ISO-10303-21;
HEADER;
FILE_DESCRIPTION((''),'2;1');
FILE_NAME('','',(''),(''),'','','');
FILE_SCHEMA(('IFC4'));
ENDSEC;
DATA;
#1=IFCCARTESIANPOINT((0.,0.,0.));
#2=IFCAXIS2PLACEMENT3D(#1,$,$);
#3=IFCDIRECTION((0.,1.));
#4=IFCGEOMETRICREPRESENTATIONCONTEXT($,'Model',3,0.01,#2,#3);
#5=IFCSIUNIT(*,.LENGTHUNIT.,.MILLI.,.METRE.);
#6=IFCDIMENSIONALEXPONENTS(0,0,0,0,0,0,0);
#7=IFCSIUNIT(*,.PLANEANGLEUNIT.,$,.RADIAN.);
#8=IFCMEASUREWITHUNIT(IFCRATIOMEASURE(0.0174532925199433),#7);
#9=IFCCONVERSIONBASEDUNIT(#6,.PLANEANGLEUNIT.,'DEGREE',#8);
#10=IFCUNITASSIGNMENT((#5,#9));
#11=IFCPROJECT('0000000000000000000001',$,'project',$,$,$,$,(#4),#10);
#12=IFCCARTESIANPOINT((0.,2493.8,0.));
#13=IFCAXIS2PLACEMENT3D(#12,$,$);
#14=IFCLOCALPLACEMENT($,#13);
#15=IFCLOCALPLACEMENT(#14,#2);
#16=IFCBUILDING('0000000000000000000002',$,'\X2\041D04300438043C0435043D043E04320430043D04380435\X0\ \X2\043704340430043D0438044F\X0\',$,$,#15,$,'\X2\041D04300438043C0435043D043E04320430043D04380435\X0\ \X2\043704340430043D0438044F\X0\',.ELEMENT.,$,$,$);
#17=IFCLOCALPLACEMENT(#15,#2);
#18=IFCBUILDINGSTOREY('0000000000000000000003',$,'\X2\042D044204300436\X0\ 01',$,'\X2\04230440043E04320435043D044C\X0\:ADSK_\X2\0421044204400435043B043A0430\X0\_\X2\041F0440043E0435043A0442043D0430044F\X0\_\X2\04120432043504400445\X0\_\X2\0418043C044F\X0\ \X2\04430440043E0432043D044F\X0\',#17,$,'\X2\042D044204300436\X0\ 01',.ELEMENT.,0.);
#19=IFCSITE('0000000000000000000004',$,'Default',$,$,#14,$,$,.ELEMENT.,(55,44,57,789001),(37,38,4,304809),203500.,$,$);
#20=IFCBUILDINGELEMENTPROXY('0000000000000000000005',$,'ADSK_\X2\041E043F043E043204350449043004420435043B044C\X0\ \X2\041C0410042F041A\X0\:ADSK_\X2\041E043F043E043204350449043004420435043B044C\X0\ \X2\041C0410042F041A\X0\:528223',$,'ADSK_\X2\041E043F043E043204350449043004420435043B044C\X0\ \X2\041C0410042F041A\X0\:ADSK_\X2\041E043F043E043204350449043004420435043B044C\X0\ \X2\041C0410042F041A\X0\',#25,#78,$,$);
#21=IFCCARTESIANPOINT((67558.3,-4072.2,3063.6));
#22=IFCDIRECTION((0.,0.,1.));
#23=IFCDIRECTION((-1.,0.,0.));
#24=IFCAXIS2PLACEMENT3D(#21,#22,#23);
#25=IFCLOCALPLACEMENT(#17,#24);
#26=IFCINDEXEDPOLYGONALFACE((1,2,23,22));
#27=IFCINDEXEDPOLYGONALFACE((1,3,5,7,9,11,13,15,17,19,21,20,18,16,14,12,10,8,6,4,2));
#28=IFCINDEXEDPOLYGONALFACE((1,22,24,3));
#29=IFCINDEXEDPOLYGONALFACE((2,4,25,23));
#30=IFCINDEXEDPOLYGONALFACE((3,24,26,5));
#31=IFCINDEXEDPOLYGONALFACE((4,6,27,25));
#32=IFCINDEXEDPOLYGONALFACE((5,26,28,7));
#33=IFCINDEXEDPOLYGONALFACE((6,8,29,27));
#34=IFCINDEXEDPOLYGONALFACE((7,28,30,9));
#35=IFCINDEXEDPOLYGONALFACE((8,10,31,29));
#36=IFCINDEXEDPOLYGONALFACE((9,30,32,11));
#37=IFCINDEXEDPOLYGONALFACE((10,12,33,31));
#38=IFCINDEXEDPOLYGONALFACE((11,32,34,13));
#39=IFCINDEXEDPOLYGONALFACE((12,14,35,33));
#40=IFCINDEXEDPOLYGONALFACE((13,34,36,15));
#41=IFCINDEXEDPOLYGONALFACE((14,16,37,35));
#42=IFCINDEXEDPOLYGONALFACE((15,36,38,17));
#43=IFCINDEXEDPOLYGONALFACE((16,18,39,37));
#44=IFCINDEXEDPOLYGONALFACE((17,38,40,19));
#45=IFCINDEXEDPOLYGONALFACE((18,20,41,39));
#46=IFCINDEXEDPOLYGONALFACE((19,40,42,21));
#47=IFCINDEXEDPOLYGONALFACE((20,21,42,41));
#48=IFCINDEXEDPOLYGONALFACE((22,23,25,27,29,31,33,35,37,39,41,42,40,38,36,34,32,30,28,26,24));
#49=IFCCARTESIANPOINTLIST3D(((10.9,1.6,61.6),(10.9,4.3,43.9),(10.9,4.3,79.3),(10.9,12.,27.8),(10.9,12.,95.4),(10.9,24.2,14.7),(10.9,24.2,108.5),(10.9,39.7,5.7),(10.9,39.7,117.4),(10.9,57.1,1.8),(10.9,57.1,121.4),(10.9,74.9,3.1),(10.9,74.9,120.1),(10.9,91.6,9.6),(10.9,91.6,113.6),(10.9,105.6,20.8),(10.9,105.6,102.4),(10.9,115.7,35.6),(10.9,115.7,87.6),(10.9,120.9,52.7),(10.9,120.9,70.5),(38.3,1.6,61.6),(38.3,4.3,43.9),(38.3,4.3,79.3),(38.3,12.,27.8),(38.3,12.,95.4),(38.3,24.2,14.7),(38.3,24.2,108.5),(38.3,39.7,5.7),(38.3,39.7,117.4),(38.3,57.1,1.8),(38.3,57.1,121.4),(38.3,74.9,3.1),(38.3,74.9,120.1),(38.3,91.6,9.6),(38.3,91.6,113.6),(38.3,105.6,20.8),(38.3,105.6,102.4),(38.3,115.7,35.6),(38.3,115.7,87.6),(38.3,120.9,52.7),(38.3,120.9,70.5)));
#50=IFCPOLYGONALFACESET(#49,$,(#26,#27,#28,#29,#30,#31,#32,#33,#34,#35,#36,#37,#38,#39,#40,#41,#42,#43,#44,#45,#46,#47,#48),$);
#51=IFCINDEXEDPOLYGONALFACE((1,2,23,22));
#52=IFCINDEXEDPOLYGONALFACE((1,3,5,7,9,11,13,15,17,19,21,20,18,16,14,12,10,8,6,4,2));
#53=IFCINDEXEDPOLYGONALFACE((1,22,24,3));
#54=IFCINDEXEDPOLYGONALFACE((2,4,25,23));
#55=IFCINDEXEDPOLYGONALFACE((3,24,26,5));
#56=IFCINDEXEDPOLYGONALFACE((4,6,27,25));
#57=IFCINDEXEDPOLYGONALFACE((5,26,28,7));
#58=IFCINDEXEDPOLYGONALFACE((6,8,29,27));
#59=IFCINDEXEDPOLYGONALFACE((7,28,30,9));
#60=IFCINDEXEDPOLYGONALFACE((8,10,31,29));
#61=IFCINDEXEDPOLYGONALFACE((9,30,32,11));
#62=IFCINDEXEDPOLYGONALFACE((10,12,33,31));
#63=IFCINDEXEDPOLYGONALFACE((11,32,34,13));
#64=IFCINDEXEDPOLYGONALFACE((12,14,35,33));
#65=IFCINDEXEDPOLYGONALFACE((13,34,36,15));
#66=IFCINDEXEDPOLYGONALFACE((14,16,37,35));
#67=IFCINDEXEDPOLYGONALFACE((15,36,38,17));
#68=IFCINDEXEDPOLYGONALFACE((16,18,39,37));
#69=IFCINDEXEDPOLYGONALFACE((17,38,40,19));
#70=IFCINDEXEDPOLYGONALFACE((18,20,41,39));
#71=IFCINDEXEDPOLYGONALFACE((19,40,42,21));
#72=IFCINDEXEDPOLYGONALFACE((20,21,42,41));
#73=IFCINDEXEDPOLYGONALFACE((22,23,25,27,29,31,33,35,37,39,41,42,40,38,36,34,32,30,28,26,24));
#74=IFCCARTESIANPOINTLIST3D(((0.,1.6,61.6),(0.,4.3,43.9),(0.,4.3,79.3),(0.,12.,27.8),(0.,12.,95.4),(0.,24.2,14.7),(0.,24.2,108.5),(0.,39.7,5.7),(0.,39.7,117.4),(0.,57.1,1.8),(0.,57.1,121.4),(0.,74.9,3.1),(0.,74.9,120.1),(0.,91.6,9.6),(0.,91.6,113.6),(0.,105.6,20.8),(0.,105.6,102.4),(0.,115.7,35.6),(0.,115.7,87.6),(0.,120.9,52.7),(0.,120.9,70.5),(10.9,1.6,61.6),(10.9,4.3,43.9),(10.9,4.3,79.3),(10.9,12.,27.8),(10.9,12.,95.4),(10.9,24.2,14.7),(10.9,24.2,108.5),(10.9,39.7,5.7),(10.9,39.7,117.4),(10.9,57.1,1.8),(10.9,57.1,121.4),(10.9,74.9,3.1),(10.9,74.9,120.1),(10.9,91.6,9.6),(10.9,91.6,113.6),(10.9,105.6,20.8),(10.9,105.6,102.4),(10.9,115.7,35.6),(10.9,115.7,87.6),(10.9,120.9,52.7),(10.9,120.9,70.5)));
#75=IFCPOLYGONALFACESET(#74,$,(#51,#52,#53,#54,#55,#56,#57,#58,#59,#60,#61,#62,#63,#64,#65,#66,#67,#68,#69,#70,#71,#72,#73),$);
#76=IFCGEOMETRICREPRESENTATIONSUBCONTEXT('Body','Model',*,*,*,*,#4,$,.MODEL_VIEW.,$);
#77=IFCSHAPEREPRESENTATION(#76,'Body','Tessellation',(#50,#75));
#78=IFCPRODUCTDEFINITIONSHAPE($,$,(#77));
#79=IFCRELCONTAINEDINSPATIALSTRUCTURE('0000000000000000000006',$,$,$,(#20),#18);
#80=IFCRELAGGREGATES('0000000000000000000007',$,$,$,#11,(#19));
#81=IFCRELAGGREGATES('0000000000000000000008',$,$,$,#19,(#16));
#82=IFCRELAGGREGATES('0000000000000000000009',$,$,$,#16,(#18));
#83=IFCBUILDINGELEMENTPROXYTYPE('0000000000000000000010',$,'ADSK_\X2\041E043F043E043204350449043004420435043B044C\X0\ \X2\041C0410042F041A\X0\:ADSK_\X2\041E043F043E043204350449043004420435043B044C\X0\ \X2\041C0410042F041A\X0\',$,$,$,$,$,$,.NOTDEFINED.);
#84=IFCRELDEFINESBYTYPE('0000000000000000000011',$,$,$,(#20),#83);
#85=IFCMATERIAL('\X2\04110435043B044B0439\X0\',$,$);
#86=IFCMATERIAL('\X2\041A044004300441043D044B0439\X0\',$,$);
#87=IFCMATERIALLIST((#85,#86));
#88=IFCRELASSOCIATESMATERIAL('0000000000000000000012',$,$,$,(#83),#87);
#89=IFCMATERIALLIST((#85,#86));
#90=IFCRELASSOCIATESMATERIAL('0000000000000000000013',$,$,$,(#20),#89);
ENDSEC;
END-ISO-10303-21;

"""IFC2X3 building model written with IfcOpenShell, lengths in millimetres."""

from ifc_helpers import new_model, entity, si_unit, converted_unit, direction, frame, frame_2d, origin, place, context, subcontext, project, spatial, circle, extrude, source, transform, mapped, material, material_list, type_object, type_shapes, element, save


model = new_model("IFC2X3")

# Units and contexts
model_context = context("Model", 3, precision=0.01, world=origin(), true_north=direction((0.0, 1.0)))
body_context = subcontext(model_context, "Body", "Model", "MODEL_VIEW")
ifc_project = project(units=[si_unit("LENGTHUNIT", "METRE", prefix="MILLI"), converted_unit("PLANEANGLEUNIT", "DEGREE", entity("IfcRatioMeasure", 0.0174532925199433), si_unit("PLANEANGLEUNIT", "RADIAN"), dimensions=[0, 0, 0, 0, 0, 0, 0])], contexts=[model_context])

# Site, building, storey
site_placement = place(None, frame((0.0, 2493.8, 0.0)))
site = spatial("IfcSite", under=ifc_project, at=site_placement, Name="Default", CompositionType="ELEMENT", RefLatitude=(55, 44, 57, 789001), RefLongitude=(37, 38, 4, 304809), RefElevation=203500.0)
building_placement = place(site_placement, origin())
building = spatial("IfcBuilding", under=site, at=building_placement, Name="Наименование здания", LongName="Наименование здания", CompositionType="ELEMENT")
storey_placement = place(building_placement, origin())
storey = spatial("IfcBuildingStorey", under=building, at=storey_placement, Name="Этаж 01", ObjectType="Уровень:ADSK_Стрелка_Проектная_Вверх_Имя уровня", LongName="Этаж 01", CompositionType="ELEMENT", Elevation=0.0)

# Building element proxy
ifc_material_1 = material(Name="Белый")
ifc_material_2 = material(Name="Красный")
ifc_material_list_1 = material_list([ifc_material_1, ifc_material_2])
ifc_material_list_2 = material_list([ifc_material_1, ifc_material_2])
building_element_proxy_type_1 = type_object("IfcBuildingElementProxyType", Name="ADSK_Оповещатель МАЯК:ADSK_Оповещатель МАЯК", PredefinedType="NOTDEFINED", material=ifc_material_list_2)
shared_shape_1 = source(origin(), body_context, "Body", "SweptSolid", [
    extrude(circle(Radius=60.0, at=frame_2d((0.0, 0.0), x_axis=(1.0, 0.0))), frame((10.9, 61.6, 61.6), z_axis=(1.0, 0.0, 0.0), x_axis=(0.0, -1.0, 0.0)), (0.0, 0.0, 1.0), 27.4),
    extrude(circle(Radius=60.0, at=frame_2d((0.0, 0.0), x_axis=(1.0, 0.0))), frame((0.0, 61.6, 61.6), z_axis=(1.0, 0.0, 0.0), x_axis=(0.0, -1.0, 0.0)), (0.0, 0.0, 1.0), 10.9),
])
type_shapes(building_element_proxy_type_1, [shared_shape_1])
proxy_1_placement = place(storey_placement, frame((67558.3, -4072.2, 3063.6), z_axis=(0.0, 0.0, 1.0), x_axis=(-1.0, 0.0, 0.0)))
element("IfcBuildingElementProxy", 1, at=proxy_1_placement, inside=storey, type_object=building_element_proxy_type_1, material=ifc_material_list_1, Name="ADSK_Оповещатель МАЯК:ADSK_Оповещатель МАЯК:528223", ObjectType="ADSK_Оповещатель МАЯК:ADSK_Оповещатель МАЯК", context=body_context, shape_type="MappedRepresentation", body=[
    mapped(shared_shape_1, transform((0.0, 0.0, 0.0), scale=1.0)),
])

save(model, "model.ifc")
